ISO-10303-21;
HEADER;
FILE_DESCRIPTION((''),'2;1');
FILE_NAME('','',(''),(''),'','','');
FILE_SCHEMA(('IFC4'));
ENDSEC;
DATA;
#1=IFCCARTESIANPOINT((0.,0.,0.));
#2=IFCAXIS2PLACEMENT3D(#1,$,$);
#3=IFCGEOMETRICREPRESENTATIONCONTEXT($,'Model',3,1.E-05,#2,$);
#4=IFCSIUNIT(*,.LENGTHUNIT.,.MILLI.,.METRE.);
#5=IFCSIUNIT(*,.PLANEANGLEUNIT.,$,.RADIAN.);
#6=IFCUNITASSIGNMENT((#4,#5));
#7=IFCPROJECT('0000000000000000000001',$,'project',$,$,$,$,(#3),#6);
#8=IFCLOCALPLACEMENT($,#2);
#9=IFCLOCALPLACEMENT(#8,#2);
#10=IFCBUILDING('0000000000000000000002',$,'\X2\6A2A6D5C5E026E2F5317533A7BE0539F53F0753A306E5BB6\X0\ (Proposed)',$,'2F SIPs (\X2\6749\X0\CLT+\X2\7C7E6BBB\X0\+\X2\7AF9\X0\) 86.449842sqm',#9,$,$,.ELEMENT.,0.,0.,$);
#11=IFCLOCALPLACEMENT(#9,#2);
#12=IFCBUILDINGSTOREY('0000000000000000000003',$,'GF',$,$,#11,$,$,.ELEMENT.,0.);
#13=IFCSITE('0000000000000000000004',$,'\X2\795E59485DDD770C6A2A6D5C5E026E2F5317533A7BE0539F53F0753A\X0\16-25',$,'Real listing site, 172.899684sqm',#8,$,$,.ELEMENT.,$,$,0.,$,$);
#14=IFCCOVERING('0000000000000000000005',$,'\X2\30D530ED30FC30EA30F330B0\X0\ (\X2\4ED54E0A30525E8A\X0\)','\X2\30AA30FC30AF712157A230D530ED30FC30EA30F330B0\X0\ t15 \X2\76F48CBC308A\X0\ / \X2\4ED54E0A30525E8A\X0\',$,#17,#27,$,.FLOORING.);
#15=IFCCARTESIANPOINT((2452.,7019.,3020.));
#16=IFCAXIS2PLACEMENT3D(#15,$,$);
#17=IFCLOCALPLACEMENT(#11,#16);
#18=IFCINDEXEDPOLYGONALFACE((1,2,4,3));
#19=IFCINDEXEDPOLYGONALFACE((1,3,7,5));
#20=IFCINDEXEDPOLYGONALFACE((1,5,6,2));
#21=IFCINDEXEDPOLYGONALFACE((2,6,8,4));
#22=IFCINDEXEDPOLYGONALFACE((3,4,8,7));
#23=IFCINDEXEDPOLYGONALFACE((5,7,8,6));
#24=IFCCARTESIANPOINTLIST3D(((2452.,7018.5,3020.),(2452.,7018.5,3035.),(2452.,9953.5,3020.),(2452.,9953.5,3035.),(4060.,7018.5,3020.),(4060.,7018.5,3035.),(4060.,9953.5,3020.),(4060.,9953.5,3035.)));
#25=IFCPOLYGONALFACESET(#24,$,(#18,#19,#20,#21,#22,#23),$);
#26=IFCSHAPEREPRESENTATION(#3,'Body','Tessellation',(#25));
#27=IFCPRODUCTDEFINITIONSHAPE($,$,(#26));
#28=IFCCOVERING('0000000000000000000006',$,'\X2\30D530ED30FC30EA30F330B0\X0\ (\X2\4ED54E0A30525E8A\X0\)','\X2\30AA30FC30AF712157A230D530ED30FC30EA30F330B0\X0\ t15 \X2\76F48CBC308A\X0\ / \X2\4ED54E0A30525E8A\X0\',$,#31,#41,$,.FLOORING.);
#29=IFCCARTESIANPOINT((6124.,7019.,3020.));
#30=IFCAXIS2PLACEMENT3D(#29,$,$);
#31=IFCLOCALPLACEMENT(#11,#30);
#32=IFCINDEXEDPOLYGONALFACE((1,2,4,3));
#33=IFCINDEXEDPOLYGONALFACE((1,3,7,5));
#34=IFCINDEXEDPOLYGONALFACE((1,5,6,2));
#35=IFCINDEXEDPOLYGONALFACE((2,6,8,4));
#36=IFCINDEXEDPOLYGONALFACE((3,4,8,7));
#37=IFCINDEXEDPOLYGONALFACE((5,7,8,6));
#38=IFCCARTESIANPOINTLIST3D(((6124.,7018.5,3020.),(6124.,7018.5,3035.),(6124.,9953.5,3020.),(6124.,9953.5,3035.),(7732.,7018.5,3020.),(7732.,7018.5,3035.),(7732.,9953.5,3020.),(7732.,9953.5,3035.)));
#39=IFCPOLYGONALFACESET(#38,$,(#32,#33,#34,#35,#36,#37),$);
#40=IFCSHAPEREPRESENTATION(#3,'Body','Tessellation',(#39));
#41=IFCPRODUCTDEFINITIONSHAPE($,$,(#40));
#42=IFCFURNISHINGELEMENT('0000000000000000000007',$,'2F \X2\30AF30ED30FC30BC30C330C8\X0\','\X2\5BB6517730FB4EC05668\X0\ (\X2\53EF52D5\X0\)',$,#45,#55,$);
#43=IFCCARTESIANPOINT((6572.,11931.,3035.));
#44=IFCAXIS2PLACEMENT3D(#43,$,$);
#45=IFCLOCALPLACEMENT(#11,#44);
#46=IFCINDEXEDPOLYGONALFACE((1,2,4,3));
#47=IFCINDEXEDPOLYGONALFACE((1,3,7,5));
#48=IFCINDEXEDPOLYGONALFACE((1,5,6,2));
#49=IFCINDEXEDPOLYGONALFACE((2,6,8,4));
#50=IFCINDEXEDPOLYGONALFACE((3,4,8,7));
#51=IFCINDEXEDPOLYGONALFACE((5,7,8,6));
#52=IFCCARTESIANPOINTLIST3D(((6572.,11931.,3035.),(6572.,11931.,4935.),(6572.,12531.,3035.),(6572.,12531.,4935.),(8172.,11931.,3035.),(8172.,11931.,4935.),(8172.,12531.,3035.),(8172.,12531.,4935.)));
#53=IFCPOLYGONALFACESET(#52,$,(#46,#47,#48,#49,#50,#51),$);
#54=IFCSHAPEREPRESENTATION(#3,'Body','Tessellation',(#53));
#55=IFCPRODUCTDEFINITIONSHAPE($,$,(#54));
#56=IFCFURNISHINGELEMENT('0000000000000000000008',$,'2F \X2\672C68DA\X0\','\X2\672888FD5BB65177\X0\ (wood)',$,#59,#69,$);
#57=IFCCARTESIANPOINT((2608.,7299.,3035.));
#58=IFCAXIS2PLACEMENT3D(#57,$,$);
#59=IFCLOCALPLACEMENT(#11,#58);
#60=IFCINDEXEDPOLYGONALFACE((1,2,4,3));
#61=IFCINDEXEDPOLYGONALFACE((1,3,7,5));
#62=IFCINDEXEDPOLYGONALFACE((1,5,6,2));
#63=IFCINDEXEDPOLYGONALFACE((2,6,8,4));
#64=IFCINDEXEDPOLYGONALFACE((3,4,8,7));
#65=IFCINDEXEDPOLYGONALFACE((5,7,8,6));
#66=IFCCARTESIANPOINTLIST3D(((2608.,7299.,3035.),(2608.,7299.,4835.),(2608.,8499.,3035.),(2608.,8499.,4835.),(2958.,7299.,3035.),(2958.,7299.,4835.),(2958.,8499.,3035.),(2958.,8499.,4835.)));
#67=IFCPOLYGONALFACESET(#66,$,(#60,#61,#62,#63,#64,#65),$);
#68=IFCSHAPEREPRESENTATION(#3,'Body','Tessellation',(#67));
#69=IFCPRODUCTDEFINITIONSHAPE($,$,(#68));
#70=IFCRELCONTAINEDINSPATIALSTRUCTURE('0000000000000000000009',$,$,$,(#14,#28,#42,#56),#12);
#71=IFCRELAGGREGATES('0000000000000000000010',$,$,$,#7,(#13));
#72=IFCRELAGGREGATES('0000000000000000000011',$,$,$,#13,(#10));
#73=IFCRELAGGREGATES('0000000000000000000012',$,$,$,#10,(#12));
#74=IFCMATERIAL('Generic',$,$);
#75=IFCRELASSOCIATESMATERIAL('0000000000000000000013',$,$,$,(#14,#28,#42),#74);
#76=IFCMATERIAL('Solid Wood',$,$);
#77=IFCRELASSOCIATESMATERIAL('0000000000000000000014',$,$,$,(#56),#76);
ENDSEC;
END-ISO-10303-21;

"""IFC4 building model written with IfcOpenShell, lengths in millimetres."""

from ifc_helpers import new_model, si_unit, frame, frame_2d, origin, place, context, project, spatial, rectangle, extrude, material, element, save


model = new_model("IFC4")

# Units and contexts
model_context = context("Model", 3, precision=1e-05, world=origin())
ifc_project = project(units=[si_unit("LENGTHUNIT", "METRE", prefix="MILLI"), si_unit("PLANEANGLEUNIT", "RADIAN")], contexts=[model_context])

# Site, building, storey
site_placement = place(None, origin())
site = spatial("IfcSite", under=ifc_project, at=site_placement, Name="神奈川県横浜市港北区篠原台町16-25", ObjectType="Real listing site, 172.899684sqm", CompositionType="ELEMENT", RefElevation=0.0)
building_placement = place(site_placement, origin())
building = spatial("IfcBuilding", under=site, at=building_placement, Name="横浜市港北区篠原台町の家 (Proposed)", ObjectType="2F SIPs (杉CLT+籾殻+竹) 86.449842sqm", CompositionType="ELEMENT", ElevationOfRefHeight=0.0, ElevationOfTerrain=0.0)
storey_placement = place(building_placement, origin())
storey = spatial("IfcBuildingStorey", under=building, at=storey_placement, Name="GF", CompositionType="ELEMENT", Elevation=0.0)

# Shared definitions
ifc_material_1 = material(Name="Solid Wood")

# Coverings
ifc_material_2 = material(Name="Generic")
covering_1_placement = place(storey_placement, frame((2452.0, 7019.0, 3020.0)))
element("IfcCovering", 1, at=covering_1_placement, inside=storey, material=ifc_material_2, Name="フローリング (仕上げ床)", Description="オーク無垢フローリング t15 直貼り / 仕上げ床", PredefinedType="FLOORING", context=model_context, shape_type="SweptSolid", body=[
    extrude(rectangle(XDim=1608.0, YDim=2935.0, at=frame_2d((804.0, 1467.0))), frame((2452.0, 7019.0, 3020.0)), (0.0, 0.0, 1.0), 15.0),
])
covering_2_placement = place(storey_placement, frame((6124.0, 7019.0, 3020.0)))
element("IfcCovering", 2, at=covering_2_placement, inside=storey, material=ifc_material_2, Name="フローリング (仕上げ床)", Description="オーク無垢フローリング t15 直貼り / 仕上げ床", PredefinedType="FLOORING", context=model_context, shape_type="SweptSolid", body=[
    extrude(rectangle(XDim=1608.0, YDim=2935.0, at=frame_2d((804.0, 1467.0))), frame((6124.0, 7019.0, 3020.0)), (0.0, 0.0, 1.0), 15.0),
])

# Furnishing elements
furnishing_1_placement = place(storey_placement, frame((6572.0, 11931.0, 3035.0)))
element("IfcFurnishingElement", 3, at=furnishing_1_placement, inside=storey, material=ifc_material_2, Name="2F クローゼット", Description="家具・什器 (可動)", context=model_context, shape_type="SweptSolid", body=[
    extrude(rectangle(XDim=1600.0, YDim=600.0, at=frame_2d((800.0, 300.0))), frame((6572.0, 11931.0, 3035.0)), (0.0, 0.0, 1.0), 1900.0),
])
furnishing_2_placement = place(storey_placement, frame((2608.0, 7299.0, 3035.0)))
element("IfcFurnishingElement", 4, at=furnishing_2_placement, inside=storey, material=ifc_material_1, Name="2F 本棚", Description="木製家具 (wood)", context=model_context, shape_type="SweptSolid", body=[
    extrude(rectangle(XDim=350.0, YDim=1200.0, at=frame_2d((175.0, 600.0))), frame((2608.0, 7299.0, 3035.0)), (0.0, 0.0, 1.0), 1800.0),
])

save(model, "model.ifc")
